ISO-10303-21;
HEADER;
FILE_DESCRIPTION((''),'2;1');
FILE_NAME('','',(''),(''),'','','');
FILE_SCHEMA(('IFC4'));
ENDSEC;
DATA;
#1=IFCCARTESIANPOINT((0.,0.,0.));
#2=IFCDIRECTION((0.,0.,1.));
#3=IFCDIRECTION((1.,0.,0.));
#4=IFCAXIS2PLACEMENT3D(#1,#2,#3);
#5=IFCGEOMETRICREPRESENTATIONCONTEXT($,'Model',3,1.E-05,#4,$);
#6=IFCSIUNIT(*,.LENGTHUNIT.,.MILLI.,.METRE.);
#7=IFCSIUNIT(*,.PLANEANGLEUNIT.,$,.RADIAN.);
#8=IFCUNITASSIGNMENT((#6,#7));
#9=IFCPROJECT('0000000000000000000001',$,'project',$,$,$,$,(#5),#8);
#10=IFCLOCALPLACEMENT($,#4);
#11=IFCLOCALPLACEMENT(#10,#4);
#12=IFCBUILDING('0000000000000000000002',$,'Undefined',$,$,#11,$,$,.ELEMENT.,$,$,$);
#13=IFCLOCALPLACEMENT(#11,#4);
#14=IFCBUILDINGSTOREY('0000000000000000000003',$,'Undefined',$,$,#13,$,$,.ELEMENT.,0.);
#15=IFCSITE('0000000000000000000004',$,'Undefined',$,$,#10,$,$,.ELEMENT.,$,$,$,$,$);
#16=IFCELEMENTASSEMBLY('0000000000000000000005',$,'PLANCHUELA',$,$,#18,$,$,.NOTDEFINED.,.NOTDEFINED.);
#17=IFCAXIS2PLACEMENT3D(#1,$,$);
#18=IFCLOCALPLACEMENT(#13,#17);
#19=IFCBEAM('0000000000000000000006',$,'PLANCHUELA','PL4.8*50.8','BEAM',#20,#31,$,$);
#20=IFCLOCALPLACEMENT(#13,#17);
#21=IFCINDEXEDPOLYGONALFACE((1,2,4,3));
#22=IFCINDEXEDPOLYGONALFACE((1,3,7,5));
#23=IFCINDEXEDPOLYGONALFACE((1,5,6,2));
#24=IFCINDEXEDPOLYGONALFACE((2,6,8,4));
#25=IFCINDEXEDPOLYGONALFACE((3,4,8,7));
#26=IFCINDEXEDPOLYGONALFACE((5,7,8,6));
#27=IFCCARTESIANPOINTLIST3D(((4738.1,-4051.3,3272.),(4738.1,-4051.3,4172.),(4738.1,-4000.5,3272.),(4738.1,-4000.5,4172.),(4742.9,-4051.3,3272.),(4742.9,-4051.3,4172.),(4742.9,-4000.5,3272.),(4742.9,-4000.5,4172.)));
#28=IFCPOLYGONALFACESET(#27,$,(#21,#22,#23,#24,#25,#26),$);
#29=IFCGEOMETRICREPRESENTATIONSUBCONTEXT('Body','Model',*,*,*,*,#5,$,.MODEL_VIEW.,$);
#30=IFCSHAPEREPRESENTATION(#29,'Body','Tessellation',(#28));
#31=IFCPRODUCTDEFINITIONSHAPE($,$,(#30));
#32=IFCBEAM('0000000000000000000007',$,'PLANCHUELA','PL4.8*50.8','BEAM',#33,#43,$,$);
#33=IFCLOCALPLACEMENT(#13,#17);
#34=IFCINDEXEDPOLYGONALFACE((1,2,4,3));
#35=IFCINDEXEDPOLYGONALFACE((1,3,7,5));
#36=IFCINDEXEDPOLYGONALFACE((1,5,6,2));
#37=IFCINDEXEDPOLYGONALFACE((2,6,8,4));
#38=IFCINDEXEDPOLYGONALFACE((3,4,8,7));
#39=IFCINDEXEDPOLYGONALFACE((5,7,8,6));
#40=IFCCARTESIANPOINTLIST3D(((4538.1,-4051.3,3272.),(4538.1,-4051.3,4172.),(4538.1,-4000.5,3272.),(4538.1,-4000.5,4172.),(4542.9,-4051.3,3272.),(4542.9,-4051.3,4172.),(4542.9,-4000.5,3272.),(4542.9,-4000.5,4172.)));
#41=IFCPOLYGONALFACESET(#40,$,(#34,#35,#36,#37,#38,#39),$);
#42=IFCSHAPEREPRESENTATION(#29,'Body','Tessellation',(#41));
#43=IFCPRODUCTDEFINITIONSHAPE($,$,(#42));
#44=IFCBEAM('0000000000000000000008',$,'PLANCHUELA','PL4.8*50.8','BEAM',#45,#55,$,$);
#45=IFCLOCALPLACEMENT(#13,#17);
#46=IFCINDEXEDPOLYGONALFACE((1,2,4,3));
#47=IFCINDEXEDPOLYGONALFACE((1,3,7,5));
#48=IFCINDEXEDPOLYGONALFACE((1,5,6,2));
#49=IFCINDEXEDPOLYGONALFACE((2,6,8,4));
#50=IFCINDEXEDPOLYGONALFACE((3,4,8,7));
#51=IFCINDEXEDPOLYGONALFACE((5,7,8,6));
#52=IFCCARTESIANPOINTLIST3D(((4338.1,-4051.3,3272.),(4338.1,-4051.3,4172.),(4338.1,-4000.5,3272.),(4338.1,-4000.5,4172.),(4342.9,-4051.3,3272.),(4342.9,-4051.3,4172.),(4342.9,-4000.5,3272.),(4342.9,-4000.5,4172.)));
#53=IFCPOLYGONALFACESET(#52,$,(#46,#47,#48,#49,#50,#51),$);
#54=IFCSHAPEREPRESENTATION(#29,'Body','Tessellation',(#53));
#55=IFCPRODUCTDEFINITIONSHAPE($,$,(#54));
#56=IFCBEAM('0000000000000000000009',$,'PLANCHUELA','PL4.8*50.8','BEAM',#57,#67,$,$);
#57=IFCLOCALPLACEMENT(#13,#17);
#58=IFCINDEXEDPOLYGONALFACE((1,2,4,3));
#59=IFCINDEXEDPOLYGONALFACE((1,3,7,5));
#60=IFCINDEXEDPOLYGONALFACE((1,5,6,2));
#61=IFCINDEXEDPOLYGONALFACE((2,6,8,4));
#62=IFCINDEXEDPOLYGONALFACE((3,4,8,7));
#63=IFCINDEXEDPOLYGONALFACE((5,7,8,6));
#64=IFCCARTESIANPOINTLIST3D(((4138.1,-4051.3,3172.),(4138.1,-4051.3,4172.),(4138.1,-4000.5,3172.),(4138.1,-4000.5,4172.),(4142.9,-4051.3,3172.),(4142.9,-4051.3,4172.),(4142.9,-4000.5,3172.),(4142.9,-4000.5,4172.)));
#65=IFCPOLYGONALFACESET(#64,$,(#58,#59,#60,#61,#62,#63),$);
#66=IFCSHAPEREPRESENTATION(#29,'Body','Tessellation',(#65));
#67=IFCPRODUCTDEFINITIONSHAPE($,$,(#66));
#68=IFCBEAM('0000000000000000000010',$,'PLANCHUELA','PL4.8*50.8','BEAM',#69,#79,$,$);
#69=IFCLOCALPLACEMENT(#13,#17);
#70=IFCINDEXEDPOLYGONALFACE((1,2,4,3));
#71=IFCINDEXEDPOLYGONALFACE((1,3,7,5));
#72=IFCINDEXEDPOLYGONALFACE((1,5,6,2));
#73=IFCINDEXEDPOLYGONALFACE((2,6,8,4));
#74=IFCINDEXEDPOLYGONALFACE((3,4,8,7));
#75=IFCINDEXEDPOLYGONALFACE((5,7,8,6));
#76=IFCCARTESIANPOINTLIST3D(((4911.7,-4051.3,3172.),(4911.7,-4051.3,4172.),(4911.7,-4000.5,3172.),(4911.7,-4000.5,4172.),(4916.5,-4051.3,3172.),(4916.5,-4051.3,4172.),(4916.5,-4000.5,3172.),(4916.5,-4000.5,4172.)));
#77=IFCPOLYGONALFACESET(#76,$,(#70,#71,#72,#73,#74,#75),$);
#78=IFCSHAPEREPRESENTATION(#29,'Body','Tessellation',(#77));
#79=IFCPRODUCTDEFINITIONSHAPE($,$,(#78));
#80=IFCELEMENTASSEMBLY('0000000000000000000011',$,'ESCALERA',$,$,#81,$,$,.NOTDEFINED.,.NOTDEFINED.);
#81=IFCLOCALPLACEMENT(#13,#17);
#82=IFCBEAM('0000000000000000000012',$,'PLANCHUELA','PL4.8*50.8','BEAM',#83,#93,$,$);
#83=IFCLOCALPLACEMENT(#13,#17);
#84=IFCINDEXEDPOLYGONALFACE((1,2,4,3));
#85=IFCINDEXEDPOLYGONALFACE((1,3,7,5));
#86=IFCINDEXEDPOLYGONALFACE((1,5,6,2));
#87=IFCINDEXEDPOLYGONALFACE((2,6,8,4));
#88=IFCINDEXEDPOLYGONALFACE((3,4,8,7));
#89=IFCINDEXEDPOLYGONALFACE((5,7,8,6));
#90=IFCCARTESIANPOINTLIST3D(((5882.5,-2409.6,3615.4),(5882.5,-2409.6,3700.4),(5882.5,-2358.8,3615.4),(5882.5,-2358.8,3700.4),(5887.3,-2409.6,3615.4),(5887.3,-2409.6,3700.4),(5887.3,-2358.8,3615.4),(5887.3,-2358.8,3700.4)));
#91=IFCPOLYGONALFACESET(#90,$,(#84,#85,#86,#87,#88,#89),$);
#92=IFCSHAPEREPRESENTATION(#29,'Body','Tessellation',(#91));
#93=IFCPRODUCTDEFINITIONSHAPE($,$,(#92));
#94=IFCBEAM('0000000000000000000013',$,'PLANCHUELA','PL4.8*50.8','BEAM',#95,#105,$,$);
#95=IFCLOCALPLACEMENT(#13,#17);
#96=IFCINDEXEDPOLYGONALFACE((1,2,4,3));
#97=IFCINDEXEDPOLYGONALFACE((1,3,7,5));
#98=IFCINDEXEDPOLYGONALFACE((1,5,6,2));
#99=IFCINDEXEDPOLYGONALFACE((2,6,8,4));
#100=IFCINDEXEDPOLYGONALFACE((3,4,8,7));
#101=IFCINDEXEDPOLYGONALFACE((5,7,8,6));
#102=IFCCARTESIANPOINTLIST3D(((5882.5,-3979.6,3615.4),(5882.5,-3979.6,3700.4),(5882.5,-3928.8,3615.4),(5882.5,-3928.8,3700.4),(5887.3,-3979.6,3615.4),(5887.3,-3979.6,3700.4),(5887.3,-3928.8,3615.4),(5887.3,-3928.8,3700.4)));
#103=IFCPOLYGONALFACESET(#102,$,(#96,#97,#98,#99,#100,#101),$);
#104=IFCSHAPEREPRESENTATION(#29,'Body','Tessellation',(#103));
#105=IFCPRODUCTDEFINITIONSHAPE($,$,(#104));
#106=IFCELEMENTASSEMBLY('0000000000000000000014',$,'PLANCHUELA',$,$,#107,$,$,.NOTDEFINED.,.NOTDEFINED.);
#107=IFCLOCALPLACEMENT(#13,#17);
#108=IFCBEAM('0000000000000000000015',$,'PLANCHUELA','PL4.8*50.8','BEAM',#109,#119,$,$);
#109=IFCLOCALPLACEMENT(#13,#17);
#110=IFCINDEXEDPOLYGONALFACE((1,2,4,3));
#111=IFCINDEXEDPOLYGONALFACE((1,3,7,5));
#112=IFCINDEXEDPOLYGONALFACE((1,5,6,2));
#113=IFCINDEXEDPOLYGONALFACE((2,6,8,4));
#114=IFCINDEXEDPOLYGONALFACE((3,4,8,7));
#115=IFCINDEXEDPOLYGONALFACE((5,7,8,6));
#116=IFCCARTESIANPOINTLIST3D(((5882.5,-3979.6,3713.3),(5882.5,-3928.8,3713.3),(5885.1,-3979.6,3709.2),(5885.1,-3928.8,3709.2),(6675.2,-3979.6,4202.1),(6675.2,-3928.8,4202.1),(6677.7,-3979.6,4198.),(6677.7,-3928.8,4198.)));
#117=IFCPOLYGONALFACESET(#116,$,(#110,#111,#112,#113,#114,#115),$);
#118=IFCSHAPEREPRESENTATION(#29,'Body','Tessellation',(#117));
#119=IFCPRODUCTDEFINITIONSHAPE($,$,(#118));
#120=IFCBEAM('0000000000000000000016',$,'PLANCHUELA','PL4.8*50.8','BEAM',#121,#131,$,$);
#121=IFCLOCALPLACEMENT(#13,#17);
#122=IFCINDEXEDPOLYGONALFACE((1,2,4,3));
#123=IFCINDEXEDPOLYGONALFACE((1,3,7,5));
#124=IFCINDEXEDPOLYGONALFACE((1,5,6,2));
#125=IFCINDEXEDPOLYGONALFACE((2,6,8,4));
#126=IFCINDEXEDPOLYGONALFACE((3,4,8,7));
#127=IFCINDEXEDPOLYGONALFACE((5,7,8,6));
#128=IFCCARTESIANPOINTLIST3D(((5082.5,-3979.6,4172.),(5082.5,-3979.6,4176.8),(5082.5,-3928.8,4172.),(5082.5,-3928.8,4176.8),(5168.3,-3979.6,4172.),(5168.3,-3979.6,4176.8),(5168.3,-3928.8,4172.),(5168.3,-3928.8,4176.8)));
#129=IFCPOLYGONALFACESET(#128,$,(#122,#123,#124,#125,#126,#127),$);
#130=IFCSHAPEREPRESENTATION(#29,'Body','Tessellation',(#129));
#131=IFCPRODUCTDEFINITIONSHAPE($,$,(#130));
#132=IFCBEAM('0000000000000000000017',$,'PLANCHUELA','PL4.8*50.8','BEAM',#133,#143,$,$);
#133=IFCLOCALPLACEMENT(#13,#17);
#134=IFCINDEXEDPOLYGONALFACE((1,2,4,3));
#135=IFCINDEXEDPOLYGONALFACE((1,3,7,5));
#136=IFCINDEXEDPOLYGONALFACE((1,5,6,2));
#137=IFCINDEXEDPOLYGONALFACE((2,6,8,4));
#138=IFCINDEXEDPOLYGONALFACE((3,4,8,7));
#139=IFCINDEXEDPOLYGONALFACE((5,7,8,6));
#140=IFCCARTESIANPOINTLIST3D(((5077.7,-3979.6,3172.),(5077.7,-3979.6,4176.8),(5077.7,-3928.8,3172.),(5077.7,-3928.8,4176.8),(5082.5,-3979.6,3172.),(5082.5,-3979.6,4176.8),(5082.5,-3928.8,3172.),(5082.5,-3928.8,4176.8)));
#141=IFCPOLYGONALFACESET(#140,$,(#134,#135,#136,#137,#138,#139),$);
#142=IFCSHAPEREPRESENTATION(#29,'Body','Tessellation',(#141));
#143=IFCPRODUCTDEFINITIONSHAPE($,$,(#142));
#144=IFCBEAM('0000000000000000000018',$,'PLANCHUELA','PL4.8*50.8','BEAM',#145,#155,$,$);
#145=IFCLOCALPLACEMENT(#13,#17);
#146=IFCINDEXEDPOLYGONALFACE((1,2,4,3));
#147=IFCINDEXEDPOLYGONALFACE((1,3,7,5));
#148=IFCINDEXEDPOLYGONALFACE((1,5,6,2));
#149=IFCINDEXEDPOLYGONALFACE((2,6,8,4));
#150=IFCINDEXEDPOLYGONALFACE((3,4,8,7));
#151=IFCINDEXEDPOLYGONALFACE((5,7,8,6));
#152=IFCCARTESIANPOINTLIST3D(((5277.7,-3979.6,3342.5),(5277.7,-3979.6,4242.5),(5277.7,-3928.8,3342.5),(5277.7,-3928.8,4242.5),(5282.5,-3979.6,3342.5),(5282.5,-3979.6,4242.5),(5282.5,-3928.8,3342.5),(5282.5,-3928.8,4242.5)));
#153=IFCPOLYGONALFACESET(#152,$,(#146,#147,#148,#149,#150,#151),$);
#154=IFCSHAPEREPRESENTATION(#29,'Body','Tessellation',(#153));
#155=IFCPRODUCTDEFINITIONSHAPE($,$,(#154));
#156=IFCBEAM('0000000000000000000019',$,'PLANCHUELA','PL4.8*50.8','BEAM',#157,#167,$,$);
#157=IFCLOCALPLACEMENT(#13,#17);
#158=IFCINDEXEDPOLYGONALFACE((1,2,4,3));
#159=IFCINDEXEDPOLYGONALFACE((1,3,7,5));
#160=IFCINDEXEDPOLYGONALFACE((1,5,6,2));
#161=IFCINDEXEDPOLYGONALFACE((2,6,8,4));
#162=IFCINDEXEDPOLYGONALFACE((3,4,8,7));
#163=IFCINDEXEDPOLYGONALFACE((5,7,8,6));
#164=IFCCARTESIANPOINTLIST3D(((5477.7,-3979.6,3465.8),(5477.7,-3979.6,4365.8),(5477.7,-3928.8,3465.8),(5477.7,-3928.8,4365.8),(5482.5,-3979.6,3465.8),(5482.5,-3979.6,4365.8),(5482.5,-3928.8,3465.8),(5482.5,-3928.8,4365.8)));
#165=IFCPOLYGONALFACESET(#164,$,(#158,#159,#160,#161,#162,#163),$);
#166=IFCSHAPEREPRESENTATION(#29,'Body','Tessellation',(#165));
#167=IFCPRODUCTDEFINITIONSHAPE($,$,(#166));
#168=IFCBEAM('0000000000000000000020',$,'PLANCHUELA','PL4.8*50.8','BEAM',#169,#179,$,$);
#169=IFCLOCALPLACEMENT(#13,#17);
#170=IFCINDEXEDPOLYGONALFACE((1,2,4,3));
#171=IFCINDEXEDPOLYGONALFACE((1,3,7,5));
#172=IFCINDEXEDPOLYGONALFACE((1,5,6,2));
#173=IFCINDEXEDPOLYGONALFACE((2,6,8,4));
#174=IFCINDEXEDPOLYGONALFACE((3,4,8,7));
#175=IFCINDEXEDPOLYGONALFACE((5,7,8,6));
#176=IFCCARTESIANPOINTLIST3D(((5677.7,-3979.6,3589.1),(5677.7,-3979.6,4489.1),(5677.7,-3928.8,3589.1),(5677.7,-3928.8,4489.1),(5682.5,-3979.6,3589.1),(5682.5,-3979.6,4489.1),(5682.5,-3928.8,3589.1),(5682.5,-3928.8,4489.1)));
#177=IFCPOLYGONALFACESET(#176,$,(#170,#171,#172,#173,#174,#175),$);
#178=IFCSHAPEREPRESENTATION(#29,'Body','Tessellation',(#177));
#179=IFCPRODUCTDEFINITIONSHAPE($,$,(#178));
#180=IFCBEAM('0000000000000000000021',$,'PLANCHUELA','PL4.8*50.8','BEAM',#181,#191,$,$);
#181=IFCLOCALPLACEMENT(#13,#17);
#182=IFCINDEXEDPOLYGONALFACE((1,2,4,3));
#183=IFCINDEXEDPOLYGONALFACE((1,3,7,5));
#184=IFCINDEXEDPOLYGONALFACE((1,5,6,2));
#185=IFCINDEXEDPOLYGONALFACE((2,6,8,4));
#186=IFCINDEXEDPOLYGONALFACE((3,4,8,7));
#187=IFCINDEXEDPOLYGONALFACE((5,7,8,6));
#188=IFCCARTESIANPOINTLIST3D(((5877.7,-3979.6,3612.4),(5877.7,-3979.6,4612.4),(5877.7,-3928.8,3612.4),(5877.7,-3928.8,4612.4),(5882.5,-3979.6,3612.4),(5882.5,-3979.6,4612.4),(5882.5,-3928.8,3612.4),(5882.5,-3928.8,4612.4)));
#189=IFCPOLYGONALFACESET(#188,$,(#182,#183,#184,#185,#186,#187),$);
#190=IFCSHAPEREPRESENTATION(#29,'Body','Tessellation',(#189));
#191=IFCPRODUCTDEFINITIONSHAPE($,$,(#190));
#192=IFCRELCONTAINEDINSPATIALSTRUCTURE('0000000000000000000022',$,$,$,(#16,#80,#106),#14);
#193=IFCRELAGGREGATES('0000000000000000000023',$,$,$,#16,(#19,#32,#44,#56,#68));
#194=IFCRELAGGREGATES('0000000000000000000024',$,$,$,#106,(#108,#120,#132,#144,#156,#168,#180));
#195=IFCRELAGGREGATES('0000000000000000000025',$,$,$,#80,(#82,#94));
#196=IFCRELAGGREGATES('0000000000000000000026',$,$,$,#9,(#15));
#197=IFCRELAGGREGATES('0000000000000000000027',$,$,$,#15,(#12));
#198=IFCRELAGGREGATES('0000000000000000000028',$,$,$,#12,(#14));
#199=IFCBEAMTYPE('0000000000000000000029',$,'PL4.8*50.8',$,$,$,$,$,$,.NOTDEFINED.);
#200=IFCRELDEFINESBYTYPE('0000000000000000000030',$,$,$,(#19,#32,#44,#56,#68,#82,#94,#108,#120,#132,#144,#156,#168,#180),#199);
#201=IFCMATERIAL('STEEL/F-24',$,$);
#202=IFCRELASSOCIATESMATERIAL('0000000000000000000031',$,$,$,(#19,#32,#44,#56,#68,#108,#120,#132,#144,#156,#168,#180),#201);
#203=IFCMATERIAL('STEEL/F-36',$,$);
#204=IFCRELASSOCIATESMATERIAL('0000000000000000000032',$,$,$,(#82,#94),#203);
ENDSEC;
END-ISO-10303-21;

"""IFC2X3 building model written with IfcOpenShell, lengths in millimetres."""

from ifc_helpers import new_model, si_unit, frame, origin_with_axes, origin_2d_with_axis, place, context, subcontext, project, spatial, rectangle, extrude, material, type_object, element, aggregate, save


model = new_model("IFC2X3")

# Units and contexts
model_context = context("Model", 3, precision=1e-05, world=origin_with_axes())
body_context = subcontext(model_context, "Body", "Model", "MODEL_VIEW")
ifc_project = project(units=[si_unit("LENGTHUNIT", "METRE", prefix="MILLI"), si_unit("PLANEANGLEUNIT", "RADIAN")], contexts=[model_context])

# Site, building, storey
site_placement = place(None, origin_with_axes())
site = spatial("IfcSite", under=ifc_project, at=site_placement, Name="Undefined", CompositionType="ELEMENT")
building_placement = place(site_placement, origin_with_axes())
building = spatial("IfcBuilding", under=site, at=building_placement, Name="Undefined", CompositionType="ELEMENT")
storey_placement = place(building_placement, origin_with_axes())
storey = spatial("IfcBuildingStorey", under=building, at=storey_placement, Name="Undefined", CompositionType="ELEMENT", Elevation=0.0)

# Element assemblies, beams
assembly_1_placement = place(storey_placement, origin_with_axes())
assembly_1 = element("IfcElementAssembly", 1, at=assembly_1_placement, inside=storey, Name="PLANCHUELA", AssemblyPlace="NOTDEFINED", PredefinedType="NOTDEFINED")
ifc_material_1 = material(Name="STEEL/F-24")
beam_type_1 = type_object("IfcBeamType", Name="PL4.8*50.8", PredefinedType="NOTDEFINED")
beam_1_placement = place(assembly_1_placement, frame((4740.5, -4025.9, 4172.0), z_axis=(0.0, -1.0, 0.0), x_axis=(0.0, 0.0, -1.0)))
beam_1 = element("IfcBeam", 2, at=beam_1_placement, type_object=beam_type_1, material=ifc_material_1, Name="PLANCHUELA", Description="PL4.8*50.8", ObjectType="BEAM", context=body_context, shape_type="SweptSolid", body=[
    extrude(rectangle(XDim=4.8, YDim=50.8, at=origin_2d_with_axis()), frame((900.0, 0.0, 0.0), z_axis=(-1.0, 0.0, 0.0), x_axis=(0.0, -1.0, 0.0)), (0.0, 0.0, 1.0), 900.0),
])
beam_2_placement = place(assembly_1_placement, frame((4540.5, -4025.9, 4172.0), z_axis=(0.0, -1.0, 0.0), x_axis=(0.0, 0.0, -1.0)))
beam_2 = element("IfcBeam", 3, at=beam_2_placement, type_object=beam_type_1, material=ifc_material_1, Name="PLANCHUELA", Description="PL4.8*50.8", ObjectType="BEAM", context=body_context, shape_type="SweptSolid", body=[
    extrude(rectangle(XDim=4.8, YDim=50.8, at=origin_2d_with_axis()), frame((900.0, 0.0, 0.0), z_axis=(-1.0, 0.0, 0.0), x_axis=(0.0, -1.0, 0.0)), (0.0, 0.0, 1.0), 900.0),
])
beam_3_placement = place(assembly_1_placement, frame((4340.5, -4025.9, 4172.0), z_axis=(0.0, -1.0, 0.0), x_axis=(0.0, 0.0, -1.0)))
beam_3 = element("IfcBeam", 4, at=beam_3_placement, type_object=beam_type_1, material=ifc_material_1, Name="PLANCHUELA", Description="PL4.8*50.8", ObjectType="BEAM", context=body_context, shape_type="SweptSolid", body=[
    extrude(rectangle(XDim=4.8, YDim=50.8, at=origin_2d_with_axis()), frame((900.0, 0.0, 0.0), z_axis=(-1.0, 0.0, 0.0), x_axis=(0.0, -1.0, 0.0)), (0.0, 0.0, 1.0), 900.0),
])
beam_4_placement = place(assembly_1_placement, frame((4140.5, -4025.9, 4172.0), z_axis=(0.0, -1.0, 0.0), x_axis=(0.0, 0.0, -1.0)))
beam_4 = element("IfcBeam", 5, at=beam_4_placement, type_object=beam_type_1, material=ifc_material_1, Name="PLANCHUELA", Description="PL4.8*50.8", ObjectType="BEAM", context=body_context, shape_type="SweptSolid", body=[
    extrude(rectangle(XDim=4.8, YDim=50.8, at=origin_2d_with_axis()), frame((1000.0, 0.0, 0.0), z_axis=(-1.0, 0.0, 0.0), x_axis=(0.0, -1.0, 0.0)), (0.0, 0.0, 1.0), 1000.0),
])
beam_5_placement = place(assembly_1_placement, frame((4914.1, -4025.9, 4172.0), z_axis=(0.0, -1.0, 0.0), x_axis=(0.0, 0.0, -1.0)))
beam_5 = element("IfcBeam", 6, at=beam_5_placement, type_object=beam_type_1, material=ifc_material_1, Name="PLANCHUELA", Description="PL4.8*50.8", ObjectType="BEAM", context=body_context, shape_type="SweptSolid", body=[
    extrude(rectangle(XDim=4.8, YDim=50.8, at=origin_2d_with_axis()), frame((1000.0, 0.0, 0.0), z_axis=(-1.0, 0.0, 0.0), x_axis=(0.0, -1.0, 0.0)), (0.0, 0.0, 1.0), 1000.0),
])
aggregate(assembly_1, [beam_1, beam_2, beam_3, beam_4, beam_5])
assembly_2_placement = place(storey_placement, origin_with_axes())
assembly_2 = element("IfcElementAssembly", 7, at=assembly_2_placement, inside=storey, Name="ESCALERA", AssemblyPlace="NOTDEFINED", PredefinedType="NOTDEFINED")
ifc_material_2 = material(Name="STEEL/F-36")
beam_6_placement = place(assembly_2_placement, frame((5884.9, -2384.2, 3700.4), z_axis=(0.0, -1.0, 0.0), x_axis=(0.0, 0.0, -1.0)))
beam_6 = element("IfcBeam", 8, at=beam_6_placement, type_object=beam_type_1, material=ifc_material_2, Name="PLANCHUELA", Description="PL4.8*50.8", ObjectType="BEAM", context=body_context, shape_type="SweptSolid", body=[
    extrude(rectangle(XDim=4.8, YDim=50.8, at=origin_2d_with_axis()), frame((85.0, 0.0, 0.0), z_axis=(-1.0, 0.0, 0.0), x_axis=(0.0, -1.0, 0.0)), (0.0, 0.0, 1.0), 85.0),
])
beam_7_placement = place(assembly_2_placement, frame((5884.9, -3954.2, 3700.4), z_axis=(0.0, -1.0, 0.0), x_axis=(0.0, 0.0, -1.0)))
beam_7 = element("IfcBeam", 9, at=beam_7_placement, type_object=beam_type_1, material=ifc_material_2, Name="PLANCHUELA", Description="PL4.8*50.8", ObjectType="BEAM", context=body_context, shape_type="SweptSolid", body=[
    extrude(rectangle(XDim=4.8, YDim=50.8, at=origin_2d_with_axis()), frame((85.0, 0.0, 0.0), z_axis=(-1.0, 0.0, 0.0), x_axis=(0.0, -1.0, 0.0)), (0.0, 0.0, 1.0), 85.0),
])
assembly_3_placement = place(storey_placement, origin_with_axes())
assembly_3 = element("IfcElementAssembly", 10, at=assembly_3_placement, inside=storey, Name="PLANCHUELA", AssemblyPlace="NOTDEFINED", PredefinedType="NOTDEFINED")
beam_8_placement = place(assembly_3_placement, frame((5883.8, -3954.2, 3711.2), z_axis=(0.0, -1.0, 0.0), x_axis=(0.851177, 0.0, 0.524879)))
beam_8 = element("IfcBeam", 11, at=beam_8_placement, type_object=beam_type_1, material=ifc_material_1, Name="PLANCHUELA", Description="PL4.8*50.8", ObjectType="BEAM", context=body_context, shape_type="SweptSolid", body=[
    extrude(rectangle(XDim=4.8, YDim=50.8, at=origin_2d_with_axis()), frame((931.3, 0.0, 0.0), z_axis=(-1.0, 0.0, 0.0), x_axis=(0.0, -1.0, 0.0)), (0.0, 0.0, 1.0), 931.3),
])
beam_9_placement = place(assembly_3_placement, frame((5082.5, -3954.2, 4174.4), z_axis=(0.0, -1.0, 0.0), x_axis=(1.0, 0.0, 0.0)))
beam_9 = element("IfcBeam", 12, at=beam_9_placement, type_object=beam_type_1, material=ifc_material_1, Name="PLANCHUELA", Description="PL4.8*50.8", ObjectType="BEAM", context=body_context, shape_type="SweptSolid", body=[
    extrude(rectangle(XDim=4.8, YDim=50.8, at=origin_2d_with_axis()), frame((85.7, 0.0, 0.0), z_axis=(-1.0, 0.0, 0.0), x_axis=(0.0, -1.0, 0.0)), (0.0, 0.0, 1.0), 85.7),
])
beam_10_placement = place(assembly_3_placement, frame((5080.1, -3954.2, 4176.8), z_axis=(0.0, -1.0, 0.0), x_axis=(0.0, 0.0, -1.0)))
beam_10 = element("IfcBeam", 13, at=beam_10_placement, type_object=beam_type_1, material=ifc_material_1, Name="PLANCHUELA", Description="PL4.8*50.8", ObjectType="BEAM", context=body_context, shape_type="SweptSolid", body=[
    extrude(rectangle(XDim=4.8, YDim=50.8, at=origin_2d_with_axis()), frame((1004.8, 0.0, 0.0), z_axis=(-1.0, 0.0, 0.0), x_axis=(0.0, -1.0, 0.0)), (0.0, 0.0, 1.0), 1004.8),
])
beam_11_placement = place(assembly_3_placement, frame((5280.1, -3954.2, 4242.5), z_axis=(0.0, -1.0, 0.0), x_axis=(0.0, 0.0, -1.0)))
beam_11 = element("IfcBeam", 14, at=beam_11_placement, type_object=beam_type_1, material=ifc_material_1, Name="PLANCHUELA", Description="PL4.8*50.8", ObjectType="BEAM", context=body_context, shape_type="SweptSolid", body=[
    extrude(rectangle(XDim=4.8, YDim=50.8, at=origin_2d_with_axis()), frame((900.0, 0.0, 0.0), z_axis=(-1.0, 0.0, 0.0), x_axis=(0.0, -1.0, 0.0)), (0.0, 0.0, 1.0), 900.0),
])
beam_12_placement = place(assembly_3_placement, frame((5480.1, -3954.2, 4365.8), z_axis=(0.0, -1.0, 0.0), x_axis=(0.0, 0.0, -1.0)))
beam_12 = element("IfcBeam", 15, at=beam_12_placement, type_object=beam_type_1, material=ifc_material_1, Name="PLANCHUELA", Description="PL4.8*50.8", ObjectType="BEAM", context=body_context, shape_type="SweptSolid", body=[
    extrude(rectangle(XDim=4.8, YDim=50.8, at=origin_2d_with_axis()), frame((900.0, 0.0, 0.0), z_axis=(-1.0, 0.0, 0.0), x_axis=(0.0, -1.0, 0.0)), (0.0, 0.0, 1.0), 900.0),
])
beam_13_placement = place(assembly_3_placement, frame((5680.1, -3954.2, 4489.1), z_axis=(0.0, -1.0, 0.0), x_axis=(0.0, 0.0, -1.0)))
beam_13 = element("IfcBeam", 16, at=beam_13_placement, type_object=beam_type_1, material=ifc_material_1, Name="PLANCHUELA", Description="PL4.8*50.8", ObjectType="BEAM", context=body_context, shape_type="SweptSolid", body=[
    extrude(rectangle(XDim=4.8, YDim=50.8, at=origin_2d_with_axis()), frame((900.0, 0.0, 0.0), z_axis=(-1.0, 0.0, 0.0), x_axis=(0.0, -1.0, 0.0)), (0.0, 0.0, 1.0), 900.0),
])
beam_14_placement = place(assembly_3_placement, frame((5880.1, -3954.2, 4612.4), z_axis=(0.0, -1.0, 0.0), x_axis=(0.0, 0.0, -1.0)))
beam_14 = element("IfcBeam", 17, at=beam_14_placement, type_object=beam_type_1, material=ifc_material_1, Name="PLANCHUELA", Description="PL4.8*50.8", ObjectType="BEAM", context=body_context, shape_type="SweptSolid", body=[
    extrude(rectangle(XDim=4.8, YDim=50.8, at=origin_2d_with_axis()), frame((1000.0, 0.0, 0.0), z_axis=(-1.0, 0.0, 0.0), x_axis=(0.0, -1.0, 0.0)), (0.0, 0.0, 1.0), 1000.0),
])
aggregate(assembly_3, [beam_8, beam_9, beam_10, beam_11, beam_12, beam_13, beam_14])

aggregate(assembly_2, [beam_6, beam_7])

save(model, "model.ifc")
